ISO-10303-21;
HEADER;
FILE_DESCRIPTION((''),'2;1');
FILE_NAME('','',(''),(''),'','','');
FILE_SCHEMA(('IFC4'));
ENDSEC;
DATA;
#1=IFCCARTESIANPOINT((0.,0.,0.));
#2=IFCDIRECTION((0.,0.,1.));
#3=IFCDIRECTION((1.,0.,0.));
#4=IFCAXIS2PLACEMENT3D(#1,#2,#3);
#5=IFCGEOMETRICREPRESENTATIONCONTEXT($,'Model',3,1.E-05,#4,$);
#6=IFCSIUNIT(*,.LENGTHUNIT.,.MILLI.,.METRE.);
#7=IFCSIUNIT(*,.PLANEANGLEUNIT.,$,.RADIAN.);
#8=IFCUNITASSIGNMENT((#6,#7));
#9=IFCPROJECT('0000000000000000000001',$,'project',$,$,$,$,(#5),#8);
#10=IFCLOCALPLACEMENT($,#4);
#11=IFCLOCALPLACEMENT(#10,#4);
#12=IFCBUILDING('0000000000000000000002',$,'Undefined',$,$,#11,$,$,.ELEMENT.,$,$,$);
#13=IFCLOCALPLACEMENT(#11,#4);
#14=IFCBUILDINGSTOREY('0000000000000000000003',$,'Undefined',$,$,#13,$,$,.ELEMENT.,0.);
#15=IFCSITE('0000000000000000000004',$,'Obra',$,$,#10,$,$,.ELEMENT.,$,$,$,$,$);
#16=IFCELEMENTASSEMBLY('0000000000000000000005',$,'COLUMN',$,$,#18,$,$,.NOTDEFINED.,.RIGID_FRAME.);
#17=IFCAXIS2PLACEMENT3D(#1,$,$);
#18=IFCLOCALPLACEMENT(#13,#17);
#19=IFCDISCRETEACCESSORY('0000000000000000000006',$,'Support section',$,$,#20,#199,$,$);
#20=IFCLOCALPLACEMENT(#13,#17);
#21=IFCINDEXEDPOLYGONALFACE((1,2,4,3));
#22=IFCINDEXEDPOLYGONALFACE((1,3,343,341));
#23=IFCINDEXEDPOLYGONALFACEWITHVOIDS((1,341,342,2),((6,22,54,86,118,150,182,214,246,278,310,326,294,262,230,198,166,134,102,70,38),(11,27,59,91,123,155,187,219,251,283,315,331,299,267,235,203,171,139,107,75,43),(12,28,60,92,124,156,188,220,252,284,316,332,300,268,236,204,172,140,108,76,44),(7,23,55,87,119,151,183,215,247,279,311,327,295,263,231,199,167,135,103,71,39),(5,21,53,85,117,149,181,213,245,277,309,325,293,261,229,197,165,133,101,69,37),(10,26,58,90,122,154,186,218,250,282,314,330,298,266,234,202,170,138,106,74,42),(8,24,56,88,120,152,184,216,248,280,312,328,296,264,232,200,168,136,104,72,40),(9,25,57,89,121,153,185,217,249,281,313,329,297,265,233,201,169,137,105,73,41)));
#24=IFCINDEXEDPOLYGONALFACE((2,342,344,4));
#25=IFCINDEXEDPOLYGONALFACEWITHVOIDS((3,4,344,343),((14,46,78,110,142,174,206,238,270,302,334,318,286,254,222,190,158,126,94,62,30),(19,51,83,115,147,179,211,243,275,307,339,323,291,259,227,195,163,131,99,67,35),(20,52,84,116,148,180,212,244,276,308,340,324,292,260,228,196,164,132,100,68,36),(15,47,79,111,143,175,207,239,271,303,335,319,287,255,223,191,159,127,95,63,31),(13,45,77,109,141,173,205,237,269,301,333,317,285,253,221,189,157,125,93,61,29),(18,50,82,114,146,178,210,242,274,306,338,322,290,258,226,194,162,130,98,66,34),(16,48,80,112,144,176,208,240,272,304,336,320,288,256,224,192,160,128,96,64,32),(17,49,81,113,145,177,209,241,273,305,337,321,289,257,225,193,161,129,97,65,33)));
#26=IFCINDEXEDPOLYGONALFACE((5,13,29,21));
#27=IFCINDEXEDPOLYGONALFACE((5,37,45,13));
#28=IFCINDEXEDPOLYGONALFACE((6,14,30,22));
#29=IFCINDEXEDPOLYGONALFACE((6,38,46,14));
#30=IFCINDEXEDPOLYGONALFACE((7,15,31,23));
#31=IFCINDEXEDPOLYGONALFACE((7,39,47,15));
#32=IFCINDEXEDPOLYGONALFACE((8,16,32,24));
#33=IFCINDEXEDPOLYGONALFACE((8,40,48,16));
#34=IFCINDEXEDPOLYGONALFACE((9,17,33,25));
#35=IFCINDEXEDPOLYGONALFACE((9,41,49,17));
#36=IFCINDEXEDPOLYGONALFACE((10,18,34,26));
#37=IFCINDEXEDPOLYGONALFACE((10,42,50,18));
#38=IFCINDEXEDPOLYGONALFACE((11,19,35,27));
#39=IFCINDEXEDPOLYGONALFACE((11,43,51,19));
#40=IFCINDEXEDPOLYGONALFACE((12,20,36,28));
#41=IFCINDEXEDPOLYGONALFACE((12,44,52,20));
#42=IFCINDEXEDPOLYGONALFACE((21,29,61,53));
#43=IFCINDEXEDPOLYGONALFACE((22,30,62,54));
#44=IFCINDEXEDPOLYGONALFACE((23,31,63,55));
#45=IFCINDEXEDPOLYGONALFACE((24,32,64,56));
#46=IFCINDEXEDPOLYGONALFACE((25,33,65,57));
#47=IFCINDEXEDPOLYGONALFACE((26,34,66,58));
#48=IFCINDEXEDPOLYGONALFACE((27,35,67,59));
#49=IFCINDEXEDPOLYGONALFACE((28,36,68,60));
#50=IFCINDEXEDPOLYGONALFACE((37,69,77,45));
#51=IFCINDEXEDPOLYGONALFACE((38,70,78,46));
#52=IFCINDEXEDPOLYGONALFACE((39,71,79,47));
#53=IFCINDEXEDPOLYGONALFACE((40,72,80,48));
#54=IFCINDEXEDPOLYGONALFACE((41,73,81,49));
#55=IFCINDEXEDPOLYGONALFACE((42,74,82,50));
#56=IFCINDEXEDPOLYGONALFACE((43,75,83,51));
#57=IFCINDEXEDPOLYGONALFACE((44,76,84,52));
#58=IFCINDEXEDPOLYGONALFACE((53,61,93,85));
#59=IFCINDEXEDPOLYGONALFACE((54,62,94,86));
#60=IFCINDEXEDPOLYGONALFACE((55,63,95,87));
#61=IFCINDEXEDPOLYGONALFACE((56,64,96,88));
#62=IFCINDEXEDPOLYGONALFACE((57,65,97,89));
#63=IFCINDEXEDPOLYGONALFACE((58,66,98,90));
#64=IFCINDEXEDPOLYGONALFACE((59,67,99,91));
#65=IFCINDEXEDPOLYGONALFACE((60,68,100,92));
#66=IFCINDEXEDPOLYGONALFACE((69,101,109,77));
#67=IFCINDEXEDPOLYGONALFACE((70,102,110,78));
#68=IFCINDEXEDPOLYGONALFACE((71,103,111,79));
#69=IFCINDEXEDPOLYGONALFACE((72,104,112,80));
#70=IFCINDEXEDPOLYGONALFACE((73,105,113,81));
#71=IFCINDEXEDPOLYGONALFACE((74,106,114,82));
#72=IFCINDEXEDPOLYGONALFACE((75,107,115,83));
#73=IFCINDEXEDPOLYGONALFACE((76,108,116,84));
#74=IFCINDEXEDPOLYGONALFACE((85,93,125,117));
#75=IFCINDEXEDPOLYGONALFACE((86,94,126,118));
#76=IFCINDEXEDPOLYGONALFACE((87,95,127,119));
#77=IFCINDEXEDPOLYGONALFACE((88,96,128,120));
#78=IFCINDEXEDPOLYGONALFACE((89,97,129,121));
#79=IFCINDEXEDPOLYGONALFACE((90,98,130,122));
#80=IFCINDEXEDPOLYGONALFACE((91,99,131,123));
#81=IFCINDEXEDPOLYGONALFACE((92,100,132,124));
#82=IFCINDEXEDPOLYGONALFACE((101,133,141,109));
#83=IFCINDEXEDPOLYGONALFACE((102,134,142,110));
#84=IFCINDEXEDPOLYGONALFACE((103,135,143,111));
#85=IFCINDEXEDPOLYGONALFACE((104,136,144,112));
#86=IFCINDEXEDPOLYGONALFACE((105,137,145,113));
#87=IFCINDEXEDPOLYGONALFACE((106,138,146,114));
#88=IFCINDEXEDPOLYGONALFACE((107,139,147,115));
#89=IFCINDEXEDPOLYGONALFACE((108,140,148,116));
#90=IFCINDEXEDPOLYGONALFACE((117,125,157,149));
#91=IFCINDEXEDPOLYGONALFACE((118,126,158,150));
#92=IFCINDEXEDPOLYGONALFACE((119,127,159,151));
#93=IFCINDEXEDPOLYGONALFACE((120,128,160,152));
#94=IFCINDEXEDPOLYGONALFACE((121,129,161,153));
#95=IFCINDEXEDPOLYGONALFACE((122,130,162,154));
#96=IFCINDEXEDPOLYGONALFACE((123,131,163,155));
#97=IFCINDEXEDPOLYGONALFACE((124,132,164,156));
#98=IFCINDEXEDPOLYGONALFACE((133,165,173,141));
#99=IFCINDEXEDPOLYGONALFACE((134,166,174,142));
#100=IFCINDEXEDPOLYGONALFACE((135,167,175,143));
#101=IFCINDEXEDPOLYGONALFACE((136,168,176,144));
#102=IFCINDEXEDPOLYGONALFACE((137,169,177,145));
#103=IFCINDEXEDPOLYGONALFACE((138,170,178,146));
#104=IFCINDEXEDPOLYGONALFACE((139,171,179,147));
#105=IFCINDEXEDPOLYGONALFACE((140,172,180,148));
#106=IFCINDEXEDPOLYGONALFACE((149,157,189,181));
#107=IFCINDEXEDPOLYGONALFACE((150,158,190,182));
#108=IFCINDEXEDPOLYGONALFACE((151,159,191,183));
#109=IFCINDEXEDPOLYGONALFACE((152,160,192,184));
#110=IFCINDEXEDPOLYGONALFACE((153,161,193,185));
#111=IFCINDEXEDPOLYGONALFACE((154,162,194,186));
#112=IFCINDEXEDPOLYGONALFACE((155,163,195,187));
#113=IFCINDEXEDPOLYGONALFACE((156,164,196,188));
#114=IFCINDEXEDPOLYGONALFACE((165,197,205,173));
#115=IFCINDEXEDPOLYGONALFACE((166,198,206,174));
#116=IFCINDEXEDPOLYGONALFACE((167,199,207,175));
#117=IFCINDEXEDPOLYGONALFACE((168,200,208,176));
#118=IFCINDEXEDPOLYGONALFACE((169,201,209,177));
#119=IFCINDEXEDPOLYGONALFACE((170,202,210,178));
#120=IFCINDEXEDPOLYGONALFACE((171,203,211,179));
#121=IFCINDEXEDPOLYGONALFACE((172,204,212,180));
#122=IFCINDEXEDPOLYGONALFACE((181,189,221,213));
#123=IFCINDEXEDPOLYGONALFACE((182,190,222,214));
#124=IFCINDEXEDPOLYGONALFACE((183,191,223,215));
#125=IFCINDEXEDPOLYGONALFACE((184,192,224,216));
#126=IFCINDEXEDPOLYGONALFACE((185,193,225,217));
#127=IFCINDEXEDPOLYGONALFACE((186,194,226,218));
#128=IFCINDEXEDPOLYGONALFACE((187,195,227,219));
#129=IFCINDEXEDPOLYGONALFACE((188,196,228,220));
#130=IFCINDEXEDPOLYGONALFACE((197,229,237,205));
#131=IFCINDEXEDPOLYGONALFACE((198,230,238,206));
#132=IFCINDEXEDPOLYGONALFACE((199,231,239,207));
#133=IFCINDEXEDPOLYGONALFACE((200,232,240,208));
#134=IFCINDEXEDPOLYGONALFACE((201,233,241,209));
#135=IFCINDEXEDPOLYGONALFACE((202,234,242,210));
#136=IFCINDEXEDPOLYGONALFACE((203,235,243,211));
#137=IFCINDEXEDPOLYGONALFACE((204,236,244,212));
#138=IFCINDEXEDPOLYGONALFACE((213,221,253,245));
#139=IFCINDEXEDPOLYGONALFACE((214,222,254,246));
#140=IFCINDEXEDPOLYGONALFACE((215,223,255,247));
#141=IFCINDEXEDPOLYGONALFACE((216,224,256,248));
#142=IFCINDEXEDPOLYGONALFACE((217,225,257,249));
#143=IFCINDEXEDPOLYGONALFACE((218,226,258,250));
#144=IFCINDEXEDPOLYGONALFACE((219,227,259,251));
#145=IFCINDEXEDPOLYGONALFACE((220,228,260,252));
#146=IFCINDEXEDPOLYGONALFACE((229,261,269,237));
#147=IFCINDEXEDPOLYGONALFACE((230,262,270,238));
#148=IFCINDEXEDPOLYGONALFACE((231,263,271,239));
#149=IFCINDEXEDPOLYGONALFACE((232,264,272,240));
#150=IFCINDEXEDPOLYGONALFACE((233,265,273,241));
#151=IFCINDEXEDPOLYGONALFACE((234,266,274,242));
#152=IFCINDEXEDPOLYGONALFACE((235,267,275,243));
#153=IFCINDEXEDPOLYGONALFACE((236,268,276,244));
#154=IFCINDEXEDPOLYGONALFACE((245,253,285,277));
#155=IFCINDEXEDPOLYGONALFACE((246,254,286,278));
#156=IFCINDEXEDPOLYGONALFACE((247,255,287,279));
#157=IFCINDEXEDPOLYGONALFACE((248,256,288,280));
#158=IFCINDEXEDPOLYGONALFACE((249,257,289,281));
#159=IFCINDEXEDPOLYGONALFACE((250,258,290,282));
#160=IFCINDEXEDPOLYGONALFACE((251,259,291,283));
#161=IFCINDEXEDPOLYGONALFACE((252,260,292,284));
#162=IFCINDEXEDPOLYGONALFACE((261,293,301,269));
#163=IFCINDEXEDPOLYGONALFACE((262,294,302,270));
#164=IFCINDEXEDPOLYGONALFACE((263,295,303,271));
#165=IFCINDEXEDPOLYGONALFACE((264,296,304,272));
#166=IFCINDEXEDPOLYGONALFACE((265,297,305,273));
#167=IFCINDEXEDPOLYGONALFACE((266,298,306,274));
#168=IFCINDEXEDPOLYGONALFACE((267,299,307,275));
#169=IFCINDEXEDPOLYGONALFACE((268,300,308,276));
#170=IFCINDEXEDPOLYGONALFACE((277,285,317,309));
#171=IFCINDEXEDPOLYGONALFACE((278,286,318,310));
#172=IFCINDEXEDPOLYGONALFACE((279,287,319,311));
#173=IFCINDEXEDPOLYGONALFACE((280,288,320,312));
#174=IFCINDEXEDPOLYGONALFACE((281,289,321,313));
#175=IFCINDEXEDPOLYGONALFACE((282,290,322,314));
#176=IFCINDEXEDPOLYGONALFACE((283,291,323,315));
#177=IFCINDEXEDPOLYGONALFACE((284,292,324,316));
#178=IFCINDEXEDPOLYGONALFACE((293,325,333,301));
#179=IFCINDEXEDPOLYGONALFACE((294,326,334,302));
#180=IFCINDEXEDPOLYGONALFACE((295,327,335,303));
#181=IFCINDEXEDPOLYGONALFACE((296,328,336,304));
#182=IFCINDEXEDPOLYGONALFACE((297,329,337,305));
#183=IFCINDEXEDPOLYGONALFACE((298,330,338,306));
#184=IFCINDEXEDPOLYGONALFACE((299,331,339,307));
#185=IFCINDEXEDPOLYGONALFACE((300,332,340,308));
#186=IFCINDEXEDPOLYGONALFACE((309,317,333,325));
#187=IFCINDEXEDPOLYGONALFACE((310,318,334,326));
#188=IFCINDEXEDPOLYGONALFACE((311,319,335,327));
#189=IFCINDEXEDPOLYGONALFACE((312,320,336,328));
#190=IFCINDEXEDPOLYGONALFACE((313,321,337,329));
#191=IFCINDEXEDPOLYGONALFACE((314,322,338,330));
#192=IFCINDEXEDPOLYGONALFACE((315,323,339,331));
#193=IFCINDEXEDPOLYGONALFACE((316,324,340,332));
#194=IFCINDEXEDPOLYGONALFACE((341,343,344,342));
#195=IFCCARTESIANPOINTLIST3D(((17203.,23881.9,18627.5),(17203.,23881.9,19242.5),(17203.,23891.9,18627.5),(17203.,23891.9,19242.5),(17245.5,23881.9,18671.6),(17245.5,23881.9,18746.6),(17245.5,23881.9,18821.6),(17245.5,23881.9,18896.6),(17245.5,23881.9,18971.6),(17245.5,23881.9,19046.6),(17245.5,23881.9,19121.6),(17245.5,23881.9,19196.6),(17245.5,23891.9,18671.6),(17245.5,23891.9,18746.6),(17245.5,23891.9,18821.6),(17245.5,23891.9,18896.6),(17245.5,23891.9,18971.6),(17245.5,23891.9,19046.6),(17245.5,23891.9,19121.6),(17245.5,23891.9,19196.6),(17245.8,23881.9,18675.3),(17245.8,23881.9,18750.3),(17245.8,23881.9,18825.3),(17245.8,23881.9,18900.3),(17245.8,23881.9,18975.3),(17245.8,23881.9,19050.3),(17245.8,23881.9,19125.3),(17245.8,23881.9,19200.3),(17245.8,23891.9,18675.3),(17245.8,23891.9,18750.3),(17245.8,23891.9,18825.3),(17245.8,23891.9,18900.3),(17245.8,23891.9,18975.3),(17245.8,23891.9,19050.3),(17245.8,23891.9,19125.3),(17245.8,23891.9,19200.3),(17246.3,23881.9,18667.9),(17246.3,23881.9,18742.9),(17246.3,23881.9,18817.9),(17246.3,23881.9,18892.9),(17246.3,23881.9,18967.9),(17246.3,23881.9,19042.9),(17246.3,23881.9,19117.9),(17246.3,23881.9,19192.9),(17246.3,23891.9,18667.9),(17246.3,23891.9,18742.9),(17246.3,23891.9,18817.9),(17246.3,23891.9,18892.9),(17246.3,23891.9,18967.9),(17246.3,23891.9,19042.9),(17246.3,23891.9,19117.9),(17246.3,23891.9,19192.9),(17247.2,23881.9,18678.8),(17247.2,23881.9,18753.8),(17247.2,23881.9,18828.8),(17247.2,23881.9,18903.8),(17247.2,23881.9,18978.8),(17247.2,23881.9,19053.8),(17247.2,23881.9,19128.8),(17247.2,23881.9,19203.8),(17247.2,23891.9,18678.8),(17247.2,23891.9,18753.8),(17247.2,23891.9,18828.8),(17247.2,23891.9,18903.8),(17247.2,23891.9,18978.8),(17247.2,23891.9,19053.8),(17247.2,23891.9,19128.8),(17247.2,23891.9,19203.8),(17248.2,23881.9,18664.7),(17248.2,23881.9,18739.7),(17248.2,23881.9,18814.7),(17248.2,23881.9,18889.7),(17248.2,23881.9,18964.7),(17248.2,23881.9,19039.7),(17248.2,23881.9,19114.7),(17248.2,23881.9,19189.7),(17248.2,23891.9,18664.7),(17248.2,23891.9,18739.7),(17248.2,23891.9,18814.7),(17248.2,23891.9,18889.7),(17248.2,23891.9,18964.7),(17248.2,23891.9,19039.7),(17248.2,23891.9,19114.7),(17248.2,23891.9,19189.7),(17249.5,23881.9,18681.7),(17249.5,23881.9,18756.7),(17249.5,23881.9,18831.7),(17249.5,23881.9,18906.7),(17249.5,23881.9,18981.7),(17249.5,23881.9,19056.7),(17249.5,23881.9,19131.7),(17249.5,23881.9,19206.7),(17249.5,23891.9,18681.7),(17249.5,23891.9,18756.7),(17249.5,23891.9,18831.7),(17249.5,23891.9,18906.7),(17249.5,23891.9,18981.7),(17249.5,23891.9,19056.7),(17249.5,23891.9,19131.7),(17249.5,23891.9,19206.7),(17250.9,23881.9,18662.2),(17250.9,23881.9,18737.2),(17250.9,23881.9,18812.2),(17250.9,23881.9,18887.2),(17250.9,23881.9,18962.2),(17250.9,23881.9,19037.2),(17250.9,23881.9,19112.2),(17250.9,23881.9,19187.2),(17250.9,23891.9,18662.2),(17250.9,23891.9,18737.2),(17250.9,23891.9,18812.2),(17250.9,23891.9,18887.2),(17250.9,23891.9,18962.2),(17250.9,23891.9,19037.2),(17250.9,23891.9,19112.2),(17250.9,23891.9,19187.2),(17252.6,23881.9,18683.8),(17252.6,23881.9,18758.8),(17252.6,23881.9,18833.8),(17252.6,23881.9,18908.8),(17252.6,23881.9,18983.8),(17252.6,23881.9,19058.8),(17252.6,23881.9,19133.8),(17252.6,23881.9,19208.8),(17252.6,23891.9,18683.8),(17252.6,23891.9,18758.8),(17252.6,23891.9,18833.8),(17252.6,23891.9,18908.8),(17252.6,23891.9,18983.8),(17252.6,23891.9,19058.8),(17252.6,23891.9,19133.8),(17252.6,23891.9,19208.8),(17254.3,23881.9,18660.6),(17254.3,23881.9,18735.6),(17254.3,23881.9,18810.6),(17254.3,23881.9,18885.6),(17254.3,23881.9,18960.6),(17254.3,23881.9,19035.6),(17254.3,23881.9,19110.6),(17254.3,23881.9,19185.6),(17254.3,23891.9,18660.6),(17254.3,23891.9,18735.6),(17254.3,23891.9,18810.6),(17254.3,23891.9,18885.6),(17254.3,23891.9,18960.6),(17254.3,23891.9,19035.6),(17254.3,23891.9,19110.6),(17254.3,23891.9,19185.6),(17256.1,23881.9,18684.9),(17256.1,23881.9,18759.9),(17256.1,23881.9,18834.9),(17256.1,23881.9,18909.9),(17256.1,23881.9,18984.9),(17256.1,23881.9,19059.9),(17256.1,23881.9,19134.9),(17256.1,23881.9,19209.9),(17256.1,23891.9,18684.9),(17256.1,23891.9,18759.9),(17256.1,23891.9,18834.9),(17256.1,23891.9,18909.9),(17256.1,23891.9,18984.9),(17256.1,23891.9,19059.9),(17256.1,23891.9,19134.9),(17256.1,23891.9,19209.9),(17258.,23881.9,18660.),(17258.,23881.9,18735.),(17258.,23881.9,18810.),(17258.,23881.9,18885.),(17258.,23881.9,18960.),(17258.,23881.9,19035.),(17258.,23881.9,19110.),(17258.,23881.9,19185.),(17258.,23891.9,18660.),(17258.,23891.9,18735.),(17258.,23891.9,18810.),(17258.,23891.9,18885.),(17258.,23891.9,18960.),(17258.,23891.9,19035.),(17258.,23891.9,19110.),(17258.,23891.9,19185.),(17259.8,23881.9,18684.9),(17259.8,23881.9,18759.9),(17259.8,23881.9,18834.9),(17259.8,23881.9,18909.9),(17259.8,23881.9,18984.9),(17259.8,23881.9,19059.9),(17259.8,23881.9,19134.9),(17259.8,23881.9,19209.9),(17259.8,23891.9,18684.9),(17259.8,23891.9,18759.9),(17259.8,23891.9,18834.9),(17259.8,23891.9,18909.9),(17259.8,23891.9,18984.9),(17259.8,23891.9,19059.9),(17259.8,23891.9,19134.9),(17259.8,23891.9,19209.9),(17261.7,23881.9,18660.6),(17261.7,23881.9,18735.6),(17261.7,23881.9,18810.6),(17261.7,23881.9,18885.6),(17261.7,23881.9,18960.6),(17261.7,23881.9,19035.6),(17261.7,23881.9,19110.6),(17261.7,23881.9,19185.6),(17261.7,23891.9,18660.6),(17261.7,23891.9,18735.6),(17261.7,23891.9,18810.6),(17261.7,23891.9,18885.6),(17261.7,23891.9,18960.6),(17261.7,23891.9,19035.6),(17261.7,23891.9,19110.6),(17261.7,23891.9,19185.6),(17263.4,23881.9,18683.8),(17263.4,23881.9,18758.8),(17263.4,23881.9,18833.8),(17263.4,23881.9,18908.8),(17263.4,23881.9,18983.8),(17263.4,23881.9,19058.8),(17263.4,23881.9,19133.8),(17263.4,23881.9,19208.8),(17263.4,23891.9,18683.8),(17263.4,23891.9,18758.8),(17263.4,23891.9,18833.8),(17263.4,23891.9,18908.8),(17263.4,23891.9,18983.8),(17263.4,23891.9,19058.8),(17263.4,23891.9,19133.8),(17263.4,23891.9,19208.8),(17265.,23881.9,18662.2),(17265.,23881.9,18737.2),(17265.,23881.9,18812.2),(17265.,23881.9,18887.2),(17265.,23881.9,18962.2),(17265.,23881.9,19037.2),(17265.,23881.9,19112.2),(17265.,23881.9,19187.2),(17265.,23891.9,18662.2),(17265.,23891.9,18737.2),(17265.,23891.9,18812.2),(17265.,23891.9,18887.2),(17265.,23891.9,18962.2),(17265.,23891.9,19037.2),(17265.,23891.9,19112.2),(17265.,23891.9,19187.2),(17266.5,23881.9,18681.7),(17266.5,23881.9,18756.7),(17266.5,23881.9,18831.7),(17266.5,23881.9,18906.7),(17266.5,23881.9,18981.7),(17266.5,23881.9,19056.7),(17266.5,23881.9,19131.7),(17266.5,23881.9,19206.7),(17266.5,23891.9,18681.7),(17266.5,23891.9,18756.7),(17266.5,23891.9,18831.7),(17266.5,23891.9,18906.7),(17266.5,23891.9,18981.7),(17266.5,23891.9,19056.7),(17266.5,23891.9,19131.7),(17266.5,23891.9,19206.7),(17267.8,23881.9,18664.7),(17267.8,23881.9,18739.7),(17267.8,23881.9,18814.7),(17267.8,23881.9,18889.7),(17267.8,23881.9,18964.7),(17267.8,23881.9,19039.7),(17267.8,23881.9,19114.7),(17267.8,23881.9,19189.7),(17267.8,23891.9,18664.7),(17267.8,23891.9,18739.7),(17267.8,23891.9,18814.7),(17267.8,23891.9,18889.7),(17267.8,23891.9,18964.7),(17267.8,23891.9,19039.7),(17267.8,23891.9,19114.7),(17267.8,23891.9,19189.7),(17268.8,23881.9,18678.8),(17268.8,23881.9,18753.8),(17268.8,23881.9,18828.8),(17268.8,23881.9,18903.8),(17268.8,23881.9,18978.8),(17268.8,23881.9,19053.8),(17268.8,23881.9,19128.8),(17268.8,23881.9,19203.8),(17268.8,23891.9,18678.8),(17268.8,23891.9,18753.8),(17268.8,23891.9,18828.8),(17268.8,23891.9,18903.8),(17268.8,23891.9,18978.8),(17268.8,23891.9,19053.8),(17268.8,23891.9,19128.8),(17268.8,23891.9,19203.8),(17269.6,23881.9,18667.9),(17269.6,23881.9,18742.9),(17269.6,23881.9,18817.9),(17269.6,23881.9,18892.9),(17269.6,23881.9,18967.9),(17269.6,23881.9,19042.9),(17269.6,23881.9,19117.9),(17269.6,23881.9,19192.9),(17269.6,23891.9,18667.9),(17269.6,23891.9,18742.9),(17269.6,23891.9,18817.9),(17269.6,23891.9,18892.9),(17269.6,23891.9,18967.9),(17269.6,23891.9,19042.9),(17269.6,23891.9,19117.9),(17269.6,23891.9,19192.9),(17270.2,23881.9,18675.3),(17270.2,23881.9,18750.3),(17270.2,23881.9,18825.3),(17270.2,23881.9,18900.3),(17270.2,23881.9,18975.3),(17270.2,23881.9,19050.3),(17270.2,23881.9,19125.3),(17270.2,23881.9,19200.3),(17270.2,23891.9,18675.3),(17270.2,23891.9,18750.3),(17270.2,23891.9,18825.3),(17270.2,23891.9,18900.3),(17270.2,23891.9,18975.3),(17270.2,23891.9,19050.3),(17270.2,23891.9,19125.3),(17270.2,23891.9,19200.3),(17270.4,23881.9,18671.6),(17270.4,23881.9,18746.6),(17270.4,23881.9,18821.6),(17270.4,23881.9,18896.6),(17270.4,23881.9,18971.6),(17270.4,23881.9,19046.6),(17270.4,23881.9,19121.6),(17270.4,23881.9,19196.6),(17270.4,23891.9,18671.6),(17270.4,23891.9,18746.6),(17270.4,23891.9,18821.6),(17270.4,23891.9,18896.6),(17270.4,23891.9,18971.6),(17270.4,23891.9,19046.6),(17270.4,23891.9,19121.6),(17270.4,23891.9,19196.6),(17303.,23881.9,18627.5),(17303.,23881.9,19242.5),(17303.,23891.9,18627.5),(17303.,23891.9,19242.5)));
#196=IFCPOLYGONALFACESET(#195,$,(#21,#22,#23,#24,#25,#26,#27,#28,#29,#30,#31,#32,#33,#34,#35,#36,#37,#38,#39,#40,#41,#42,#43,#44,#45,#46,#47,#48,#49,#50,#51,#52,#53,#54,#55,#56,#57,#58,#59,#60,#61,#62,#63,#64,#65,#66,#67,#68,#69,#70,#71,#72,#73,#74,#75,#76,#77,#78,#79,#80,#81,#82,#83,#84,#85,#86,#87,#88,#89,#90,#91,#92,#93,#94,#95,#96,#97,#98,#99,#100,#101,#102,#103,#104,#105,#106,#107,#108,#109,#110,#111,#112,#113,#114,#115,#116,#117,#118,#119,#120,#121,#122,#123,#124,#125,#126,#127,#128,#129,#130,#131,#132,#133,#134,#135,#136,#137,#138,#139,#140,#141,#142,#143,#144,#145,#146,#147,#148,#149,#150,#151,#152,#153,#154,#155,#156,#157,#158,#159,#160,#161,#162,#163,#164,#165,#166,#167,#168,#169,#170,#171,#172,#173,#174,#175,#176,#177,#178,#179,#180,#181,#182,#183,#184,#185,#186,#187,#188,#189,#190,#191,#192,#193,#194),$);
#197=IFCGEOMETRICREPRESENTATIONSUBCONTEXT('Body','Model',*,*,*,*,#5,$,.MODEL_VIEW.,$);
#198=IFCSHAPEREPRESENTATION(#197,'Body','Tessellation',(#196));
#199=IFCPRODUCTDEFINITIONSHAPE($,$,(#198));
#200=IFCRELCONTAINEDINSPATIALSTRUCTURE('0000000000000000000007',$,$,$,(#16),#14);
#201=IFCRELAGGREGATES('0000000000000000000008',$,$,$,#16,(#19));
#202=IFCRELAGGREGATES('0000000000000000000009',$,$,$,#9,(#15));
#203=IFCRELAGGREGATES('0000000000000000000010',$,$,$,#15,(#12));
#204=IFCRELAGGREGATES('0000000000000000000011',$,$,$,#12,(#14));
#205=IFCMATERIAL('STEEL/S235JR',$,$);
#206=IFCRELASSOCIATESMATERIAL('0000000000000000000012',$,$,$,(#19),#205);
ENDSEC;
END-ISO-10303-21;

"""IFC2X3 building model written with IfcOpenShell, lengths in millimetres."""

from ifc_helpers import new_model, si_unit, frame, origin_with_axes, origin_2d_with_axis, place, context, subcontext, project, spatial, rectangle, circle, extrude, source, transform, mapped, material, element, aggregate, save


model = new_model("IFC2X3")

# Units and contexts
model_context = context("Model", 3, precision=1e-05, world=origin_with_axes())
body_context = subcontext(model_context, "Body", "Model", "MODEL_VIEW")
ifc_project = project(units=[si_unit("LENGTHUNIT", "METRE", prefix="MILLI"), si_unit("PLANEANGLEUNIT", "RADIAN")], contexts=[model_context])

# Site, building, storey
site_placement = place(None, origin_with_axes())
site = spatial("IfcSite", under=ifc_project, at=site_placement, Name="Obra", CompositionType="ELEMENT")
building_placement = place(site_placement, origin_with_axes())
building = spatial("IfcBuilding", under=site, at=building_placement, Name="Undefined", CompositionType="ELEMENT")
storey_placement = place(building_placement, origin_with_axes())
storey = spatial("IfcBuildingStorey", under=building, at=storey_placement, Name="Undefined", CompositionType="ELEMENT", Elevation=0.0)

# Element assembly
ifc_material_1 = material(Name="STEEL/S235JR")
assembly_1_placement = place(storey_placement, origin_with_axes())
assembly_1 = element("IfcElementAssembly", 1, at=assembly_1_placement, inside=storey, Name="COLUMN", AssemblyPlace="NOTDEFINED", PredefinedType="RIGID_FRAME")

# Discrete accessory, opening
discrete_accessory_1_placement = place(assembly_1_placement, frame((17253.0, 23886.9, 18627.5), z_axis=(0.0, 0.0, 1.0), x_axis=(-1.0, 0.0, 0.0)))
discrete_accessory_1 = element("IfcDiscreteAccessory", 2, at=discrete_accessory_1_placement, material=ifc_material_1, Name="Support section", context=body_context, shape_type="SweptSolid", body=[
    extrude(rectangle(XDim=10.0, YDim=100.0, at=origin_2d_with_axis()), frame((0.0, 0.0, 615.0), z_axis=(0.0, 0.0, -1.0), x_axis=(0.0, 1.0, 0.0)), (0.0, 0.0, 1.0), 615.0),
])
shared_shape_1 = source(origin_with_axes(), body_context, "Body", "SweptSolid", [
    extrude(circle(Radius=12.5, at=origin_2d_with_axis()), frame((0.0, -15.1, 0.0), z_axis=(0.0, 1.0, 0.0), x_axis=(1.0, 0.0, 0.0)), (0.0, 0.0, 1.0), 10.2),
])
opening_1_placement = place(assembly_1_placement, frame((17213.0, 23896.9, 19350.0), z_axis=(1.0, 0.0, 0.0), x_axis=(0.0, 0.0, -1.0)))
element("IfcOpeningElement", 3, at=opening_1_placement, cuts=discrete_accessory_1, ObjectType="Opening", context=body_context, shape_type="MappedRepresentation", body=[
    mapped(shared_shape_1, transform((152.5, 0.0, 45.0))),
    mapped(shared_shape_1, transform((227.5, 0.0, 45.0))),
    mapped(shared_shape_1, transform((302.5, 0.0, 45.0))),
    mapped(shared_shape_1, transform((377.5, 0.0, 45.0))),
    mapped(shared_shape_1, transform((452.5, 0.0, 45.0))),
    mapped(shared_shape_1, transform((527.5, 0.0, 45.0))),
    mapped(shared_shape_1, transform((602.5, 0.0, 45.0))),
    mapped(shared_shape_1, transform((677.5, 0.0, 45.0))),
])
aggregate(assembly_1, [discrete_accessory_1])

save(model, "model.ifc")
